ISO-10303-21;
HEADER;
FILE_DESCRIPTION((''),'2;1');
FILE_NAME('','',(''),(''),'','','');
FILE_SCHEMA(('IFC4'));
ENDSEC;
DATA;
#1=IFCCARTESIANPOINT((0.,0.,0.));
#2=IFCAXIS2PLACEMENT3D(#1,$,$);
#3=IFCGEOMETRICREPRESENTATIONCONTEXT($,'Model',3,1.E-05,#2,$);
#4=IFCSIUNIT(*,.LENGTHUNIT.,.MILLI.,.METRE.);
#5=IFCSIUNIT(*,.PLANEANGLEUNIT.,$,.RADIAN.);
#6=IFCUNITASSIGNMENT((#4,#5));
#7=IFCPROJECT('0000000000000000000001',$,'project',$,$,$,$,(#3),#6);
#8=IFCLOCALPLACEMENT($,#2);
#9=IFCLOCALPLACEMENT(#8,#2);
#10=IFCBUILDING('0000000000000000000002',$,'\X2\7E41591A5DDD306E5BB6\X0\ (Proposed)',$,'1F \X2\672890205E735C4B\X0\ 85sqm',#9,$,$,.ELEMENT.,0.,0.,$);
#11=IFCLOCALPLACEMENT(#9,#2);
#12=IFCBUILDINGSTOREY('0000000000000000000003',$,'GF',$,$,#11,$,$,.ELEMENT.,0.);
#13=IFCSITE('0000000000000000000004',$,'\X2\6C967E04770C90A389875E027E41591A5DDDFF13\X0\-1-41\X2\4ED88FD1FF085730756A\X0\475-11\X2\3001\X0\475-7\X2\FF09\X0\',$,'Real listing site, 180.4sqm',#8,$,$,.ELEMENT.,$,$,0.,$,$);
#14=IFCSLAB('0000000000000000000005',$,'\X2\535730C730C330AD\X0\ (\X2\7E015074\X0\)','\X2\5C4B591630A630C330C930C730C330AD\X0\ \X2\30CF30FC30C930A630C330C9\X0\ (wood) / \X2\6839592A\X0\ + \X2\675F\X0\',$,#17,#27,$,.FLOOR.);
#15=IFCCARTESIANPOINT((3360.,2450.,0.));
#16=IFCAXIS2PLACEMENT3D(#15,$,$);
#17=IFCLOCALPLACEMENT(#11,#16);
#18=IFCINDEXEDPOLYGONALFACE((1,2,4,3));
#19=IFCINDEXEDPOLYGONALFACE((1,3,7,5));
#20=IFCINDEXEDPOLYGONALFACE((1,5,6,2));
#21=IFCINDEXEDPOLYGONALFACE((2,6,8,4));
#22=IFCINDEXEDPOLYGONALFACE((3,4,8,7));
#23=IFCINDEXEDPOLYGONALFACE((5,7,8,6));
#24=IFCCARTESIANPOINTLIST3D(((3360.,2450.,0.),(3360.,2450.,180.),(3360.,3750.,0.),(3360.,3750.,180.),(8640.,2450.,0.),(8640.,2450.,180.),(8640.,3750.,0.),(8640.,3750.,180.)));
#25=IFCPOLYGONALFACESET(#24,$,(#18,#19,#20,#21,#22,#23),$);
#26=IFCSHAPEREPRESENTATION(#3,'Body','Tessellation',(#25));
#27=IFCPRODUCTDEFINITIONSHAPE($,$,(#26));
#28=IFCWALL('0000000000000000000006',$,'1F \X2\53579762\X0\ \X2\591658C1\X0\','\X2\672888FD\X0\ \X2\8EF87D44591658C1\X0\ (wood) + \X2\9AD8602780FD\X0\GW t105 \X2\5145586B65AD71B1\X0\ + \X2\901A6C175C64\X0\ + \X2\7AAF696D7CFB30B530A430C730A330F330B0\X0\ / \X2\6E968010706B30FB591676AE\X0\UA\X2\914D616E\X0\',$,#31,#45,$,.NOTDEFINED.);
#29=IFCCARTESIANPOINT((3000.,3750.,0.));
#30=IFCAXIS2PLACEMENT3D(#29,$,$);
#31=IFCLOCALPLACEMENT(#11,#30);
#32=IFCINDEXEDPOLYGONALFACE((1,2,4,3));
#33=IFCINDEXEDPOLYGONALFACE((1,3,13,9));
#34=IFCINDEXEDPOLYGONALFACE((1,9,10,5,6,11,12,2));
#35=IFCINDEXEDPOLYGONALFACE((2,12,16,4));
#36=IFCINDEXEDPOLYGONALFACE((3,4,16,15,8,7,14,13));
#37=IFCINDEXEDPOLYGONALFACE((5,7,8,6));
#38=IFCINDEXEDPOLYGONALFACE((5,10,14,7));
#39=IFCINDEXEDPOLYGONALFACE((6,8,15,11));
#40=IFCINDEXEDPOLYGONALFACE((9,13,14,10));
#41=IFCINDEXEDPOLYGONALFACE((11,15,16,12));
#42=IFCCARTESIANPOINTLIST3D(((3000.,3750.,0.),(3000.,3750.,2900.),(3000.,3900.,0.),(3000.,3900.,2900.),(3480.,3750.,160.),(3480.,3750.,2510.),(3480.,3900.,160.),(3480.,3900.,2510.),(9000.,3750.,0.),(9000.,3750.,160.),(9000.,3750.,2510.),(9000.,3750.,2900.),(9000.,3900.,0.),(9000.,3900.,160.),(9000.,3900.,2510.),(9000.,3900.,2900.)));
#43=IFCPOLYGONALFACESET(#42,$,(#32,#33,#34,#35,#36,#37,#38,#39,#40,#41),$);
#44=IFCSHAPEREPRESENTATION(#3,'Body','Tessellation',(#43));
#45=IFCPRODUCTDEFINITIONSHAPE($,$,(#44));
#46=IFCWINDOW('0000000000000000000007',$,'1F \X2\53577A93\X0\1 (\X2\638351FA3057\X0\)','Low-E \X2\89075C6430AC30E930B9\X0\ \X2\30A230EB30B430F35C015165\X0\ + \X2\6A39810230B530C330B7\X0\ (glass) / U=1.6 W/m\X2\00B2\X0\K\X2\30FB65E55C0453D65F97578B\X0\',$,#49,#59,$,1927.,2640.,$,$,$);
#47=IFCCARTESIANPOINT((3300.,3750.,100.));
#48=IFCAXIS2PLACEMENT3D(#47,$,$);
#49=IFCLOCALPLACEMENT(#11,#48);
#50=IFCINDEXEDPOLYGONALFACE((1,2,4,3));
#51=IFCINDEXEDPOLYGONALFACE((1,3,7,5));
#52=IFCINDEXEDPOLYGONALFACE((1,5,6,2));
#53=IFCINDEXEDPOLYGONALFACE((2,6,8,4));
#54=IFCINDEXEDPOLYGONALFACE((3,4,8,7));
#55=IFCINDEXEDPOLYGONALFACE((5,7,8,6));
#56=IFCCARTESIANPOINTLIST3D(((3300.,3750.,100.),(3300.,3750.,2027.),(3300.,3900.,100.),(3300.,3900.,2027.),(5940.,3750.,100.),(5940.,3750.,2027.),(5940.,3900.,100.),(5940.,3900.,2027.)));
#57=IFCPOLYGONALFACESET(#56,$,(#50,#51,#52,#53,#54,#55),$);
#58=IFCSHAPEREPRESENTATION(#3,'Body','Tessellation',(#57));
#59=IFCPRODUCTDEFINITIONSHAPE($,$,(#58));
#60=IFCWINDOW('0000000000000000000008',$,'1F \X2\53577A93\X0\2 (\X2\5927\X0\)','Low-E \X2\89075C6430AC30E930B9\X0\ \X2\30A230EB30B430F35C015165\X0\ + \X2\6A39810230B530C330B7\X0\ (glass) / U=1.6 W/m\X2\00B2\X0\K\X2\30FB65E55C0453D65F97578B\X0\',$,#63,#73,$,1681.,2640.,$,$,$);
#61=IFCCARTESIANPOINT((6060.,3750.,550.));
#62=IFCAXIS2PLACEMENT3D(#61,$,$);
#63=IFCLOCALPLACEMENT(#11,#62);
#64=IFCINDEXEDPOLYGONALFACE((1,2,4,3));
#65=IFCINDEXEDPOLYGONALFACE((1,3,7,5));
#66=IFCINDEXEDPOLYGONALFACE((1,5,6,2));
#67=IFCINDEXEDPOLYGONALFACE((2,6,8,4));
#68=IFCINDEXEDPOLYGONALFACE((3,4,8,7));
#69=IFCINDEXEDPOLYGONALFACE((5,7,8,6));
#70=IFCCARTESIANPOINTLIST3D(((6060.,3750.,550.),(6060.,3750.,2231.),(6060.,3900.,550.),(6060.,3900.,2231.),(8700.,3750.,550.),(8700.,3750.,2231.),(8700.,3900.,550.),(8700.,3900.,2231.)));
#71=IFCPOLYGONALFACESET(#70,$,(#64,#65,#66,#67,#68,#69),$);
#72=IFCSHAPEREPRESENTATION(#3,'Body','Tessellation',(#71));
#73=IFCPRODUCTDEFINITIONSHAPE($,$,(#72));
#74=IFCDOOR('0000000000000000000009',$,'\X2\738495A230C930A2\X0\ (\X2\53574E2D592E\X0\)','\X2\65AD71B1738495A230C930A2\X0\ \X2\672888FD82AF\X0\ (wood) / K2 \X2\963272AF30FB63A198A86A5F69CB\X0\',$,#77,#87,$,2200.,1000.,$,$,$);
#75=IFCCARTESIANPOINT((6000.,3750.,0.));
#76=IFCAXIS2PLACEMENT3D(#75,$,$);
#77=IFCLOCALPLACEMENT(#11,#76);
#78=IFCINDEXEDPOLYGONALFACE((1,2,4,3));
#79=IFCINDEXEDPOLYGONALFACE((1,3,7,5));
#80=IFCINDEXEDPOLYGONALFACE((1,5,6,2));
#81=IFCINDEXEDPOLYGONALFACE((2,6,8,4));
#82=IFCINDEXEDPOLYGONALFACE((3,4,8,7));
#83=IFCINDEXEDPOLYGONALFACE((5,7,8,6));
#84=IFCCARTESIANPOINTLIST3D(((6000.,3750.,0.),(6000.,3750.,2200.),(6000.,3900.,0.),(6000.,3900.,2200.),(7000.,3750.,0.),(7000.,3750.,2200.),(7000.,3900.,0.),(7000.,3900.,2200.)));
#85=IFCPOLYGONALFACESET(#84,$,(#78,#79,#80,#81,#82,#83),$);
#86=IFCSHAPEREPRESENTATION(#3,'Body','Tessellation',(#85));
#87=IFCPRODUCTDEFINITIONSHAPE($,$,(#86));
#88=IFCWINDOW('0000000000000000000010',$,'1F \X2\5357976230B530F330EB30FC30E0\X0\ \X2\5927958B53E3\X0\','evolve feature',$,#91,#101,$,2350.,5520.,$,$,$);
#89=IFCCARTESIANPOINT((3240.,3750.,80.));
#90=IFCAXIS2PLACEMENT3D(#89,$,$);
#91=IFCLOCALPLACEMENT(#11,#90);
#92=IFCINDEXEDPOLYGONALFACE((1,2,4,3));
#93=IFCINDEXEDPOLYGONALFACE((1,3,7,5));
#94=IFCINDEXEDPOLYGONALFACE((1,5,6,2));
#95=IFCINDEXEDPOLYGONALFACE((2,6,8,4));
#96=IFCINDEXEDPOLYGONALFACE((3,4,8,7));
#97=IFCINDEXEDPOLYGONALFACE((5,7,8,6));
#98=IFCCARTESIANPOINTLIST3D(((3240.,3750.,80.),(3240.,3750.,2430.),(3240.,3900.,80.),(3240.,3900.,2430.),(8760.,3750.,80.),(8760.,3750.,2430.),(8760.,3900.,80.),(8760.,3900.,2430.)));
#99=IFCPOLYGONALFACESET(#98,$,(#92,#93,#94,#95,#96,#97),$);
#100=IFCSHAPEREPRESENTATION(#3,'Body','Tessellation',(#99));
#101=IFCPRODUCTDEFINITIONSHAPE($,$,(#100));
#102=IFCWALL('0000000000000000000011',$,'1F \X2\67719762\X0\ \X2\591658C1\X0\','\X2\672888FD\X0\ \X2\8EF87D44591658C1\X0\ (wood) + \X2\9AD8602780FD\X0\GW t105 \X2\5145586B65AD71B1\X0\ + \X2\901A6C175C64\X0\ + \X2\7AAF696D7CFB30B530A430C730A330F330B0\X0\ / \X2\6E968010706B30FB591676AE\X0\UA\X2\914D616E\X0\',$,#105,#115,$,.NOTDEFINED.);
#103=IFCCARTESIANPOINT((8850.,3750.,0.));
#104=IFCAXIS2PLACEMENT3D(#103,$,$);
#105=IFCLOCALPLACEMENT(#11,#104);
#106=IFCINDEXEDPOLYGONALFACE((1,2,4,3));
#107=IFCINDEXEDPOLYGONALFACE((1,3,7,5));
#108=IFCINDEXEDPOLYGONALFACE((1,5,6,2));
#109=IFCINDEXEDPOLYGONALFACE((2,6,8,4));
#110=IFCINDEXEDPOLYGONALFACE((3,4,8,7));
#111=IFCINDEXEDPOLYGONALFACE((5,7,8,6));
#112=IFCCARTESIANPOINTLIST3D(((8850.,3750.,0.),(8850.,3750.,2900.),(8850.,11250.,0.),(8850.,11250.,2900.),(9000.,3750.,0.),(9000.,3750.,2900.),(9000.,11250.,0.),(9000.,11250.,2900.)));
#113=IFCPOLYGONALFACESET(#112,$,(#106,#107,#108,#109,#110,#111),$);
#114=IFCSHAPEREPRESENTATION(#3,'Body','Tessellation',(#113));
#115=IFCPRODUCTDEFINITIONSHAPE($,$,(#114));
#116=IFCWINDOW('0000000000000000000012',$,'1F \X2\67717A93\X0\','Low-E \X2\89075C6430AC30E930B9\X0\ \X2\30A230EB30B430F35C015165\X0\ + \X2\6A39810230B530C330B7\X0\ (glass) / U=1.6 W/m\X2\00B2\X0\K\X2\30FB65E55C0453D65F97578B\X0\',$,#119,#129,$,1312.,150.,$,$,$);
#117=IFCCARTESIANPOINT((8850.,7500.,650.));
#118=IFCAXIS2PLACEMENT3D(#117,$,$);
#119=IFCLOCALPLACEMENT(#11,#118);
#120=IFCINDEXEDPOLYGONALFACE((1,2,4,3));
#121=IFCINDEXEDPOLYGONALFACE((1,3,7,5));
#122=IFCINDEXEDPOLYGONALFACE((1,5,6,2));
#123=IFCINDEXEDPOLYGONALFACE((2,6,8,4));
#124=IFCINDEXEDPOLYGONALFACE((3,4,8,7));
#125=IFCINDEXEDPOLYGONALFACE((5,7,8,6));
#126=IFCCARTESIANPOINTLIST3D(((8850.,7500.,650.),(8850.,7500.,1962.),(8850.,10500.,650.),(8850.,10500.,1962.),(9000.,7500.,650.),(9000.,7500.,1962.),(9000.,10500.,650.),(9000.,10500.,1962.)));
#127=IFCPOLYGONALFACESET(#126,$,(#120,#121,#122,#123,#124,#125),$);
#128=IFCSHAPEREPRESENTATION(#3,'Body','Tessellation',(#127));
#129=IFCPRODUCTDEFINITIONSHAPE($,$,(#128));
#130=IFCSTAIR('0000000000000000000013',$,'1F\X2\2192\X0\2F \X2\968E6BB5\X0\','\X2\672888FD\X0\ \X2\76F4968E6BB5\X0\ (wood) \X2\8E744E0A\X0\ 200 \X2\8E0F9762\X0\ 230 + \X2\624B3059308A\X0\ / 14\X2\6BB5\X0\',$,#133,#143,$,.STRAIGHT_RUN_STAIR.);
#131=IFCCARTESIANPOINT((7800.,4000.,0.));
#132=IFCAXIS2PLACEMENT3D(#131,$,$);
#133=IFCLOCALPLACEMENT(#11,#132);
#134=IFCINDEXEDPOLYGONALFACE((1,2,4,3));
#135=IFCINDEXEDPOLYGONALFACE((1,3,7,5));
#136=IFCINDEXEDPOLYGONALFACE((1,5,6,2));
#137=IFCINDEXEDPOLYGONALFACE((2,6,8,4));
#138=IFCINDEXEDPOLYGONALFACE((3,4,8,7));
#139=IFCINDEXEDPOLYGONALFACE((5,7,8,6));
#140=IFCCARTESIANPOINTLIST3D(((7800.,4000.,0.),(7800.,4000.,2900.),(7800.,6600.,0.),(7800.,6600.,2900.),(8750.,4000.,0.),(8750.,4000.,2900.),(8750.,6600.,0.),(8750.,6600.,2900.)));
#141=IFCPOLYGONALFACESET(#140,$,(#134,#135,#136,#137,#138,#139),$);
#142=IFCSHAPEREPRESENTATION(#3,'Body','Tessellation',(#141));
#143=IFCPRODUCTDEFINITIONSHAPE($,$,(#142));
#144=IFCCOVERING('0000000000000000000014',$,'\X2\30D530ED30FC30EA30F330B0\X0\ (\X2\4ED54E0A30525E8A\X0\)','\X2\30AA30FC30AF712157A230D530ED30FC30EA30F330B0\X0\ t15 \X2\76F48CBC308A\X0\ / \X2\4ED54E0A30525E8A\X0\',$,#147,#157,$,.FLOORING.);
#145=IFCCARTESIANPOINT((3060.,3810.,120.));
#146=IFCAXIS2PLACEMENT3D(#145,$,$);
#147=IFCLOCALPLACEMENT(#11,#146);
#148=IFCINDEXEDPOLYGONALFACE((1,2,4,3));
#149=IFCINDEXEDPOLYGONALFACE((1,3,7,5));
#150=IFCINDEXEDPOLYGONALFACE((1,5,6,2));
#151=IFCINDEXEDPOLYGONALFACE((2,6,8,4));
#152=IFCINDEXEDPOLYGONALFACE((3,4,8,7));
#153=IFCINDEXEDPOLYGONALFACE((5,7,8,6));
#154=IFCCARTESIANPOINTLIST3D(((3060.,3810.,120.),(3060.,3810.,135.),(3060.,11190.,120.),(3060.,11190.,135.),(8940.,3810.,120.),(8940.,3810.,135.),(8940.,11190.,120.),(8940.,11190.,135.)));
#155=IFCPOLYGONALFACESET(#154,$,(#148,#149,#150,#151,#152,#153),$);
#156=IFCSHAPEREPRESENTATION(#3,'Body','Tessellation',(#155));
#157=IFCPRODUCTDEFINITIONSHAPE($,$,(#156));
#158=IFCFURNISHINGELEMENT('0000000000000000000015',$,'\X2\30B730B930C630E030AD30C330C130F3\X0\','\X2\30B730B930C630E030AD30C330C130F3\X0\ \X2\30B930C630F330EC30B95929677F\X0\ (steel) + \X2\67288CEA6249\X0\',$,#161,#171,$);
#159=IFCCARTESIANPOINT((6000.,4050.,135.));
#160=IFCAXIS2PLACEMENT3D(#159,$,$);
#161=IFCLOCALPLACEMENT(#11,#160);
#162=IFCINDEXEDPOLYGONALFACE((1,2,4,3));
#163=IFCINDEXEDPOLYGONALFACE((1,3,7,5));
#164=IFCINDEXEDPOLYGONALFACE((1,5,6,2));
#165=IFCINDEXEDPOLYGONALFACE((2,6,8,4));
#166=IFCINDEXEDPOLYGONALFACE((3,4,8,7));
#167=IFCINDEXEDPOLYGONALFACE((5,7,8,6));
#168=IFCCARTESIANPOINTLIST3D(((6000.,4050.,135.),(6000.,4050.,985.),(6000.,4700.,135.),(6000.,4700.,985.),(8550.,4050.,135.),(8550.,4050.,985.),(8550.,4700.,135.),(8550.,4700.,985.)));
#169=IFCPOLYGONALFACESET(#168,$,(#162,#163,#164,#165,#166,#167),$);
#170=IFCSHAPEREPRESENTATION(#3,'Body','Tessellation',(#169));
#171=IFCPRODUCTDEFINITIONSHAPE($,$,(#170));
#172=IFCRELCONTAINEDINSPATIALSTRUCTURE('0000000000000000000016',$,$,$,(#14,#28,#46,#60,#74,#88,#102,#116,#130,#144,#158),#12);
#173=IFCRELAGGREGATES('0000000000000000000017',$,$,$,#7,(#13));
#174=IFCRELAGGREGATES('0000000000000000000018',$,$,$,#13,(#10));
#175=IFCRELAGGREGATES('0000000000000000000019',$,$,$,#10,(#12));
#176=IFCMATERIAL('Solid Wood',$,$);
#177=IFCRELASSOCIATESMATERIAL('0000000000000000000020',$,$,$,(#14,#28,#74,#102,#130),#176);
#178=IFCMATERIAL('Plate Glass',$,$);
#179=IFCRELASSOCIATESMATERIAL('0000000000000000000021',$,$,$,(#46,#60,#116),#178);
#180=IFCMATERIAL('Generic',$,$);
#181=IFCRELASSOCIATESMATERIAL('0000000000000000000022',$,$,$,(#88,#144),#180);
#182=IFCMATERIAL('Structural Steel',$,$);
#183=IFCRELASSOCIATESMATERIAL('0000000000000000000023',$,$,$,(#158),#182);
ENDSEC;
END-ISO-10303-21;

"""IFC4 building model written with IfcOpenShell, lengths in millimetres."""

from ifc_helpers import new_model, si_unit, frame, frame_2d, origin, place, context, project, spatial, rectangle, extrude, material, element, fill, save


model = new_model("IFC4")

# Units and contexts
model_context = context("Model", 3, precision=1e-05, world=origin())
ifc_project = project(units=[si_unit("LENGTHUNIT", "METRE", prefix="MILLI"), si_unit("PLANEANGLEUNIT", "RADIAN")], contexts=[model_context])

# Site, building, storey
site_placement = place(None, origin())
site = spatial("IfcSite", under=ifc_project, at=site_placement, Name="沖縄県那覇市繁多川３-1-41付近（地番475-11、475-7）", ObjectType="Real listing site, 180.4sqm", CompositionType="ELEMENT", RefElevation=0.0)
building_placement = place(site_placement, origin())
building = spatial("IfcBuilding", under=site, at=building_placement, Name="繁多川の家 (Proposed)", ObjectType="1F 木造平屋 85sqm", CompositionType="ELEMENT", ElevationOfRefHeight=0.0, ElevationOfTerrain=0.0)
storey_placement = place(building_placement, origin())
storey = spatial("IfcBuildingStorey", under=building, at=storey_placement, Name="GF", CompositionType="ELEMENT", Elevation=0.0)

# Slab
ifc_material_1 = material(Name="Solid Wood")
slab_1_placement = place(storey_placement, frame((3360.0, 2450.0, 0.0)))
element("IfcSlab", 1, at=slab_1_placement, inside=storey, material=ifc_material_1, Name="南デッキ (縁側)", Description="屋外ウッドデッキ ハードウッド (wood) / 根太 + 束", PredefinedType="FLOOR", context=model_context, shape_type="SweptSolid", body=[
    extrude(rectangle(XDim=5280.0, YDim=1300.0, at=frame_2d((2640.0, 650.0))), frame((3360.0, 2450.0, 0.0)), (0.0, 0.0, 1.0), 180.0),
])
ifc_material_2 = material(Name="Generic")

# Wall, openings, windows, door
wall_1_placement = place(storey_placement, frame((3000.0, 3750.0, 0.0)))
wall_1 = element("IfcWall", 2, at=wall_1_placement, inside=storey, material=ifc_material_1, Name="1F 南面 外壁", Description="木製 軸組外壁 (wood) + 高性能GW t105 充填断熱 + 通気層 + 窯業系サイディング / 準耐火・外皮UA配慮", PredefinedType="NOTDEFINED", context=model_context, shape_type="SweptSolid", body=[
    extrude(rectangle(XDim=6000.0, YDim=150.0, at=frame_2d((3000.0, 75.0))), frame((3000.0, 3750.0, 0.0)), (0.0, 0.0, 1.0), 2900.0),
])
opening_1_placement = place(storey_placement, frame((3300.0, 3750.0, 100.0)))
opening_1 = element("IfcOpeningElement", 3, at=opening_1_placement, cuts=wall_1, PredefinedType="NOTDEFINED", context=model_context, shape_type="SweptSolid", body=[
    extrude(rectangle(XDim=2640.0, YDim=150.0, at=frame_2d((1320.0, 75.0))), frame((3300.0, 3750.0, 100.0)), (0.0, 0.0, 1.0), 1927.0),
])
opening_2_placement = place(storey_placement, frame((6060.0, 3750.0, 550.0)))
opening_2 = element("IfcOpeningElement", 4, at=opening_2_placement, cuts=wall_1, PredefinedType="NOTDEFINED", context=model_context, shape_type="SweptSolid", body=[
    extrude(rectangle(XDim=2640.0, YDim=150.0, at=frame_2d((1320.0, 75.0))), frame((6060.0, 3750.0, 550.0)), (0.0, 0.0, 1.0), 1681.0),
])
opening_3_placement = place(storey_placement, frame((6000.0, 3750.0, 0.0)))
opening_3 = element("IfcOpeningElement", 5, at=opening_3_placement, cuts=wall_1, PredefinedType="NOTDEFINED", context=model_context, shape_type="SweptSolid", body=[
    extrude(rectangle(XDim=1000.0, YDim=150.0, at=frame_2d((500.0, 75.0))), frame((6000.0, 3750.0, 0.0)), (0.0, 0.0, 1.0), 2200.0),
])
opening_4_placement = place(storey_placement, frame((3240.0, 3750.0, 80.0)))
opening_4 = element("IfcOpeningElement", 6, at=opening_4_placement, cuts=wall_1, PredefinedType="NOTDEFINED", context=model_context, shape_type="SweptSolid", body=[
    extrude(rectangle(XDim=5520.0, YDim=150.0, at=frame_2d((2760.0, 75.0))), frame((3240.0, 3750.0, 80.0)), (0.0, 0.0, 1.0), 2350.0),
])
ifc_material_3 = material(Name="Plate Glass")
window_1_placement = place(storey_placement, frame((3300.0, 3750.0, 100.0)))
window_1 = element("IfcWindow", 7, at=window_1_placement, inside=storey, material=ifc_material_3, Name="1F 南窓1 (掃出し)", Description="Low-E 複層ガラス アルゴン封入 + 樹脂サッシ (glass) / U=1.6 W/m²K・日射取得型", OverallHeight=1927.0, OverallWidth=2640.0, context=model_context, shape_type="SweptSolid", body=[
    extrude(rectangle(XDim=2640.0, YDim=150.0, at=frame_2d((1320.0, 75.0))), frame((3300.0, 3750.0, 100.0)), (0.0, 0.0, 1.0), 1927.0),
])
fill(opening_1, window_1)
window_2_placement = place(storey_placement, frame((6060.0, 3750.0, 550.0)))
window_2 = element("IfcWindow", 8, at=window_2_placement, inside=storey, material=ifc_material_3, Name="1F 南窓2 (大)", Description="Low-E 複層ガラス アルゴン封入 + 樹脂サッシ (glass) / U=1.6 W/m²K・日射取得型", OverallHeight=1681.0, OverallWidth=2640.0, context=model_context, shape_type="SweptSolid", body=[
    extrude(rectangle(XDim=2640.0, YDim=150.0, at=frame_2d((1320.0, 75.0))), frame((6060.0, 3750.0, 550.0)), (0.0, 0.0, 1.0), 1681.0),
])
fill(opening_2, window_2)
door_placement = place(storey_placement, frame((6000.0, 3750.0, 0.0)))
door = element("IfcDoor", 9, at=door_placement, inside=storey, material=ifc_material_1, Name="玄関ドア (南中央)", Description="断熱玄関ドア 木製芯 (wood) / K2 防犯・採風機構", OverallHeight=2200.0, OverallWidth=1000.0, context=model_context, shape_type="SweptSolid", body=[
    extrude(rectangle(XDim=1000.0, YDim=150.0, at=frame_2d((500.0, 75.0))), frame((6000.0, 3750.0, 0.0)), (0.0, 0.0, 1.0), 2200.0),
])
fill(opening_3, door)
window_3_placement = place(storey_placement, frame((3240.0, 3750.0, 80.0)))
window_3 = element("IfcWindow", 10, at=window_3_placement, inside=storey, material=ifc_material_2, Name="1F 南面サンルーム 大開口", Description="evolve feature", OverallHeight=2350.0, OverallWidth=5520.0, context=model_context, shape_type="SweptSolid", body=[
    extrude(rectangle(XDim=5520.0, YDim=150.0, at=frame_2d((2760.0, 75.0))), frame((3240.0, 3750.0, 80.0)), (0.0, 0.0, 1.0), 2350.0),
])
fill(opening_4, window_3)

# Wall, opening, window
wall_2_placement = place(storey_placement, frame((8850.0, 3750.0, 0.0)))
wall_2 = element("IfcWall", 11, at=wall_2_placement, inside=storey, material=ifc_material_1, Name="1F 東面 外壁", Description="木製 軸組外壁 (wood) + 高性能GW t105 充填断熱 + 通気層 + 窯業系サイディング / 準耐火・外皮UA配慮", PredefinedType="NOTDEFINED", context=model_context, shape_type="SweptSolid", body=[
    extrude(rectangle(XDim=150.0, YDim=7500.0, at=frame_2d((75.0, 3750.0))), frame((8850.0, 3750.0, 0.0)), (0.0, 0.0, 1.0), 2900.0),
])
opening_5_placement = place(storey_placement, frame((8850.0, 7500.0, 650.0)))
opening_5 = element("IfcOpeningElement", 12, at=opening_5_placement, cuts=wall_2, PredefinedType="NOTDEFINED", context=model_context, shape_type="SweptSolid", body=[
    extrude(rectangle(XDim=150.0, YDim=3000.0, at=frame_2d((75.0, 1500.0))), frame((8850.0, 7500.0, 650.0)), (0.0, 0.0, 1.0), 1312.0),
])
window_4_placement = place(storey_placement, frame((8850.0, 7500.0, 650.0)))
window_4 = element("IfcWindow", 13, at=window_4_placement, inside=storey, material=ifc_material_3, Name="1F 東窓", Description="Low-E 複層ガラス アルゴン封入 + 樹脂サッシ (glass) / U=1.6 W/m²K・日射取得型", OverallHeight=1312.0, OverallWidth=150.0, context=model_context, shape_type="SweptSolid", body=[
    extrude(rectangle(XDim=150.0, YDim=3000.0, at=frame_2d((75.0, 1500.0))), frame((8850.0, 7500.0, 650.0)), (0.0, 0.0, 1.0), 1312.0),
])
fill(opening_5, window_4)

# Stair
stair_placement = place(storey_placement, frame((7800.0, 4000.0, 0.0)))
element("IfcStair", 14, at=stair_placement, inside=storey, material=ifc_material_1, Name="1F→2F 階段", Description="木製 直階段 (wood) 蹴上 200 踏面 230 + 手すり / 14段", PredefinedType="STRAIGHT_RUN_STAIR", context=model_context, shape_type="SweptSolid", body=[
    extrude(rectangle(XDim=950.0, YDim=2600.0, at=frame_2d((475.0, 1300.0))), frame((7800.0, 4000.0, 0.0)), (0.0, 0.0, 1.0), 2900.0),
])

# Covering
covering_placement = place(storey_placement, frame((3060.0, 3810.0, 120.0)))
element("IfcCovering", 15, at=covering_placement, inside=storey, material=ifc_material_2, Name="フローリング (仕上げ床)", Description="オーク無垢フローリング t15 直貼り / 仕上げ床", PredefinedType="FLOORING", context=model_context, shape_type="SweptSolid", body=[
    extrude(rectangle(XDim=5880.0, YDim=7380.0, at=frame_2d((2940.0, 3690.0))), frame((3060.0, 3810.0, 120.0)), (0.0, 0.0, 1.0), 15.0),
])

# Furnishing element
ifc_material_4 = material(Name="Structural Steel")
furnishing_placement = place(storey_placement, frame((6000.0, 4050.0, 135.0)))
element("IfcFurnishingElement", 16, at=furnishing_placement, inside=storey, material=ifc_material_4, Name="システムキッチン", Description="システムキッチン ステンレス天板 (steel) + 木質扉", context=model_context, shape_type="SweptSolid", body=[
    extrude(rectangle(XDim=2550.0, YDim=650.0, at=frame_2d((1275.0, 325.0))), frame((6000.0, 4050.0, 135.0)), (0.0, 0.0, 1.0), 850.0),
])

save(model, "model.ifc")
